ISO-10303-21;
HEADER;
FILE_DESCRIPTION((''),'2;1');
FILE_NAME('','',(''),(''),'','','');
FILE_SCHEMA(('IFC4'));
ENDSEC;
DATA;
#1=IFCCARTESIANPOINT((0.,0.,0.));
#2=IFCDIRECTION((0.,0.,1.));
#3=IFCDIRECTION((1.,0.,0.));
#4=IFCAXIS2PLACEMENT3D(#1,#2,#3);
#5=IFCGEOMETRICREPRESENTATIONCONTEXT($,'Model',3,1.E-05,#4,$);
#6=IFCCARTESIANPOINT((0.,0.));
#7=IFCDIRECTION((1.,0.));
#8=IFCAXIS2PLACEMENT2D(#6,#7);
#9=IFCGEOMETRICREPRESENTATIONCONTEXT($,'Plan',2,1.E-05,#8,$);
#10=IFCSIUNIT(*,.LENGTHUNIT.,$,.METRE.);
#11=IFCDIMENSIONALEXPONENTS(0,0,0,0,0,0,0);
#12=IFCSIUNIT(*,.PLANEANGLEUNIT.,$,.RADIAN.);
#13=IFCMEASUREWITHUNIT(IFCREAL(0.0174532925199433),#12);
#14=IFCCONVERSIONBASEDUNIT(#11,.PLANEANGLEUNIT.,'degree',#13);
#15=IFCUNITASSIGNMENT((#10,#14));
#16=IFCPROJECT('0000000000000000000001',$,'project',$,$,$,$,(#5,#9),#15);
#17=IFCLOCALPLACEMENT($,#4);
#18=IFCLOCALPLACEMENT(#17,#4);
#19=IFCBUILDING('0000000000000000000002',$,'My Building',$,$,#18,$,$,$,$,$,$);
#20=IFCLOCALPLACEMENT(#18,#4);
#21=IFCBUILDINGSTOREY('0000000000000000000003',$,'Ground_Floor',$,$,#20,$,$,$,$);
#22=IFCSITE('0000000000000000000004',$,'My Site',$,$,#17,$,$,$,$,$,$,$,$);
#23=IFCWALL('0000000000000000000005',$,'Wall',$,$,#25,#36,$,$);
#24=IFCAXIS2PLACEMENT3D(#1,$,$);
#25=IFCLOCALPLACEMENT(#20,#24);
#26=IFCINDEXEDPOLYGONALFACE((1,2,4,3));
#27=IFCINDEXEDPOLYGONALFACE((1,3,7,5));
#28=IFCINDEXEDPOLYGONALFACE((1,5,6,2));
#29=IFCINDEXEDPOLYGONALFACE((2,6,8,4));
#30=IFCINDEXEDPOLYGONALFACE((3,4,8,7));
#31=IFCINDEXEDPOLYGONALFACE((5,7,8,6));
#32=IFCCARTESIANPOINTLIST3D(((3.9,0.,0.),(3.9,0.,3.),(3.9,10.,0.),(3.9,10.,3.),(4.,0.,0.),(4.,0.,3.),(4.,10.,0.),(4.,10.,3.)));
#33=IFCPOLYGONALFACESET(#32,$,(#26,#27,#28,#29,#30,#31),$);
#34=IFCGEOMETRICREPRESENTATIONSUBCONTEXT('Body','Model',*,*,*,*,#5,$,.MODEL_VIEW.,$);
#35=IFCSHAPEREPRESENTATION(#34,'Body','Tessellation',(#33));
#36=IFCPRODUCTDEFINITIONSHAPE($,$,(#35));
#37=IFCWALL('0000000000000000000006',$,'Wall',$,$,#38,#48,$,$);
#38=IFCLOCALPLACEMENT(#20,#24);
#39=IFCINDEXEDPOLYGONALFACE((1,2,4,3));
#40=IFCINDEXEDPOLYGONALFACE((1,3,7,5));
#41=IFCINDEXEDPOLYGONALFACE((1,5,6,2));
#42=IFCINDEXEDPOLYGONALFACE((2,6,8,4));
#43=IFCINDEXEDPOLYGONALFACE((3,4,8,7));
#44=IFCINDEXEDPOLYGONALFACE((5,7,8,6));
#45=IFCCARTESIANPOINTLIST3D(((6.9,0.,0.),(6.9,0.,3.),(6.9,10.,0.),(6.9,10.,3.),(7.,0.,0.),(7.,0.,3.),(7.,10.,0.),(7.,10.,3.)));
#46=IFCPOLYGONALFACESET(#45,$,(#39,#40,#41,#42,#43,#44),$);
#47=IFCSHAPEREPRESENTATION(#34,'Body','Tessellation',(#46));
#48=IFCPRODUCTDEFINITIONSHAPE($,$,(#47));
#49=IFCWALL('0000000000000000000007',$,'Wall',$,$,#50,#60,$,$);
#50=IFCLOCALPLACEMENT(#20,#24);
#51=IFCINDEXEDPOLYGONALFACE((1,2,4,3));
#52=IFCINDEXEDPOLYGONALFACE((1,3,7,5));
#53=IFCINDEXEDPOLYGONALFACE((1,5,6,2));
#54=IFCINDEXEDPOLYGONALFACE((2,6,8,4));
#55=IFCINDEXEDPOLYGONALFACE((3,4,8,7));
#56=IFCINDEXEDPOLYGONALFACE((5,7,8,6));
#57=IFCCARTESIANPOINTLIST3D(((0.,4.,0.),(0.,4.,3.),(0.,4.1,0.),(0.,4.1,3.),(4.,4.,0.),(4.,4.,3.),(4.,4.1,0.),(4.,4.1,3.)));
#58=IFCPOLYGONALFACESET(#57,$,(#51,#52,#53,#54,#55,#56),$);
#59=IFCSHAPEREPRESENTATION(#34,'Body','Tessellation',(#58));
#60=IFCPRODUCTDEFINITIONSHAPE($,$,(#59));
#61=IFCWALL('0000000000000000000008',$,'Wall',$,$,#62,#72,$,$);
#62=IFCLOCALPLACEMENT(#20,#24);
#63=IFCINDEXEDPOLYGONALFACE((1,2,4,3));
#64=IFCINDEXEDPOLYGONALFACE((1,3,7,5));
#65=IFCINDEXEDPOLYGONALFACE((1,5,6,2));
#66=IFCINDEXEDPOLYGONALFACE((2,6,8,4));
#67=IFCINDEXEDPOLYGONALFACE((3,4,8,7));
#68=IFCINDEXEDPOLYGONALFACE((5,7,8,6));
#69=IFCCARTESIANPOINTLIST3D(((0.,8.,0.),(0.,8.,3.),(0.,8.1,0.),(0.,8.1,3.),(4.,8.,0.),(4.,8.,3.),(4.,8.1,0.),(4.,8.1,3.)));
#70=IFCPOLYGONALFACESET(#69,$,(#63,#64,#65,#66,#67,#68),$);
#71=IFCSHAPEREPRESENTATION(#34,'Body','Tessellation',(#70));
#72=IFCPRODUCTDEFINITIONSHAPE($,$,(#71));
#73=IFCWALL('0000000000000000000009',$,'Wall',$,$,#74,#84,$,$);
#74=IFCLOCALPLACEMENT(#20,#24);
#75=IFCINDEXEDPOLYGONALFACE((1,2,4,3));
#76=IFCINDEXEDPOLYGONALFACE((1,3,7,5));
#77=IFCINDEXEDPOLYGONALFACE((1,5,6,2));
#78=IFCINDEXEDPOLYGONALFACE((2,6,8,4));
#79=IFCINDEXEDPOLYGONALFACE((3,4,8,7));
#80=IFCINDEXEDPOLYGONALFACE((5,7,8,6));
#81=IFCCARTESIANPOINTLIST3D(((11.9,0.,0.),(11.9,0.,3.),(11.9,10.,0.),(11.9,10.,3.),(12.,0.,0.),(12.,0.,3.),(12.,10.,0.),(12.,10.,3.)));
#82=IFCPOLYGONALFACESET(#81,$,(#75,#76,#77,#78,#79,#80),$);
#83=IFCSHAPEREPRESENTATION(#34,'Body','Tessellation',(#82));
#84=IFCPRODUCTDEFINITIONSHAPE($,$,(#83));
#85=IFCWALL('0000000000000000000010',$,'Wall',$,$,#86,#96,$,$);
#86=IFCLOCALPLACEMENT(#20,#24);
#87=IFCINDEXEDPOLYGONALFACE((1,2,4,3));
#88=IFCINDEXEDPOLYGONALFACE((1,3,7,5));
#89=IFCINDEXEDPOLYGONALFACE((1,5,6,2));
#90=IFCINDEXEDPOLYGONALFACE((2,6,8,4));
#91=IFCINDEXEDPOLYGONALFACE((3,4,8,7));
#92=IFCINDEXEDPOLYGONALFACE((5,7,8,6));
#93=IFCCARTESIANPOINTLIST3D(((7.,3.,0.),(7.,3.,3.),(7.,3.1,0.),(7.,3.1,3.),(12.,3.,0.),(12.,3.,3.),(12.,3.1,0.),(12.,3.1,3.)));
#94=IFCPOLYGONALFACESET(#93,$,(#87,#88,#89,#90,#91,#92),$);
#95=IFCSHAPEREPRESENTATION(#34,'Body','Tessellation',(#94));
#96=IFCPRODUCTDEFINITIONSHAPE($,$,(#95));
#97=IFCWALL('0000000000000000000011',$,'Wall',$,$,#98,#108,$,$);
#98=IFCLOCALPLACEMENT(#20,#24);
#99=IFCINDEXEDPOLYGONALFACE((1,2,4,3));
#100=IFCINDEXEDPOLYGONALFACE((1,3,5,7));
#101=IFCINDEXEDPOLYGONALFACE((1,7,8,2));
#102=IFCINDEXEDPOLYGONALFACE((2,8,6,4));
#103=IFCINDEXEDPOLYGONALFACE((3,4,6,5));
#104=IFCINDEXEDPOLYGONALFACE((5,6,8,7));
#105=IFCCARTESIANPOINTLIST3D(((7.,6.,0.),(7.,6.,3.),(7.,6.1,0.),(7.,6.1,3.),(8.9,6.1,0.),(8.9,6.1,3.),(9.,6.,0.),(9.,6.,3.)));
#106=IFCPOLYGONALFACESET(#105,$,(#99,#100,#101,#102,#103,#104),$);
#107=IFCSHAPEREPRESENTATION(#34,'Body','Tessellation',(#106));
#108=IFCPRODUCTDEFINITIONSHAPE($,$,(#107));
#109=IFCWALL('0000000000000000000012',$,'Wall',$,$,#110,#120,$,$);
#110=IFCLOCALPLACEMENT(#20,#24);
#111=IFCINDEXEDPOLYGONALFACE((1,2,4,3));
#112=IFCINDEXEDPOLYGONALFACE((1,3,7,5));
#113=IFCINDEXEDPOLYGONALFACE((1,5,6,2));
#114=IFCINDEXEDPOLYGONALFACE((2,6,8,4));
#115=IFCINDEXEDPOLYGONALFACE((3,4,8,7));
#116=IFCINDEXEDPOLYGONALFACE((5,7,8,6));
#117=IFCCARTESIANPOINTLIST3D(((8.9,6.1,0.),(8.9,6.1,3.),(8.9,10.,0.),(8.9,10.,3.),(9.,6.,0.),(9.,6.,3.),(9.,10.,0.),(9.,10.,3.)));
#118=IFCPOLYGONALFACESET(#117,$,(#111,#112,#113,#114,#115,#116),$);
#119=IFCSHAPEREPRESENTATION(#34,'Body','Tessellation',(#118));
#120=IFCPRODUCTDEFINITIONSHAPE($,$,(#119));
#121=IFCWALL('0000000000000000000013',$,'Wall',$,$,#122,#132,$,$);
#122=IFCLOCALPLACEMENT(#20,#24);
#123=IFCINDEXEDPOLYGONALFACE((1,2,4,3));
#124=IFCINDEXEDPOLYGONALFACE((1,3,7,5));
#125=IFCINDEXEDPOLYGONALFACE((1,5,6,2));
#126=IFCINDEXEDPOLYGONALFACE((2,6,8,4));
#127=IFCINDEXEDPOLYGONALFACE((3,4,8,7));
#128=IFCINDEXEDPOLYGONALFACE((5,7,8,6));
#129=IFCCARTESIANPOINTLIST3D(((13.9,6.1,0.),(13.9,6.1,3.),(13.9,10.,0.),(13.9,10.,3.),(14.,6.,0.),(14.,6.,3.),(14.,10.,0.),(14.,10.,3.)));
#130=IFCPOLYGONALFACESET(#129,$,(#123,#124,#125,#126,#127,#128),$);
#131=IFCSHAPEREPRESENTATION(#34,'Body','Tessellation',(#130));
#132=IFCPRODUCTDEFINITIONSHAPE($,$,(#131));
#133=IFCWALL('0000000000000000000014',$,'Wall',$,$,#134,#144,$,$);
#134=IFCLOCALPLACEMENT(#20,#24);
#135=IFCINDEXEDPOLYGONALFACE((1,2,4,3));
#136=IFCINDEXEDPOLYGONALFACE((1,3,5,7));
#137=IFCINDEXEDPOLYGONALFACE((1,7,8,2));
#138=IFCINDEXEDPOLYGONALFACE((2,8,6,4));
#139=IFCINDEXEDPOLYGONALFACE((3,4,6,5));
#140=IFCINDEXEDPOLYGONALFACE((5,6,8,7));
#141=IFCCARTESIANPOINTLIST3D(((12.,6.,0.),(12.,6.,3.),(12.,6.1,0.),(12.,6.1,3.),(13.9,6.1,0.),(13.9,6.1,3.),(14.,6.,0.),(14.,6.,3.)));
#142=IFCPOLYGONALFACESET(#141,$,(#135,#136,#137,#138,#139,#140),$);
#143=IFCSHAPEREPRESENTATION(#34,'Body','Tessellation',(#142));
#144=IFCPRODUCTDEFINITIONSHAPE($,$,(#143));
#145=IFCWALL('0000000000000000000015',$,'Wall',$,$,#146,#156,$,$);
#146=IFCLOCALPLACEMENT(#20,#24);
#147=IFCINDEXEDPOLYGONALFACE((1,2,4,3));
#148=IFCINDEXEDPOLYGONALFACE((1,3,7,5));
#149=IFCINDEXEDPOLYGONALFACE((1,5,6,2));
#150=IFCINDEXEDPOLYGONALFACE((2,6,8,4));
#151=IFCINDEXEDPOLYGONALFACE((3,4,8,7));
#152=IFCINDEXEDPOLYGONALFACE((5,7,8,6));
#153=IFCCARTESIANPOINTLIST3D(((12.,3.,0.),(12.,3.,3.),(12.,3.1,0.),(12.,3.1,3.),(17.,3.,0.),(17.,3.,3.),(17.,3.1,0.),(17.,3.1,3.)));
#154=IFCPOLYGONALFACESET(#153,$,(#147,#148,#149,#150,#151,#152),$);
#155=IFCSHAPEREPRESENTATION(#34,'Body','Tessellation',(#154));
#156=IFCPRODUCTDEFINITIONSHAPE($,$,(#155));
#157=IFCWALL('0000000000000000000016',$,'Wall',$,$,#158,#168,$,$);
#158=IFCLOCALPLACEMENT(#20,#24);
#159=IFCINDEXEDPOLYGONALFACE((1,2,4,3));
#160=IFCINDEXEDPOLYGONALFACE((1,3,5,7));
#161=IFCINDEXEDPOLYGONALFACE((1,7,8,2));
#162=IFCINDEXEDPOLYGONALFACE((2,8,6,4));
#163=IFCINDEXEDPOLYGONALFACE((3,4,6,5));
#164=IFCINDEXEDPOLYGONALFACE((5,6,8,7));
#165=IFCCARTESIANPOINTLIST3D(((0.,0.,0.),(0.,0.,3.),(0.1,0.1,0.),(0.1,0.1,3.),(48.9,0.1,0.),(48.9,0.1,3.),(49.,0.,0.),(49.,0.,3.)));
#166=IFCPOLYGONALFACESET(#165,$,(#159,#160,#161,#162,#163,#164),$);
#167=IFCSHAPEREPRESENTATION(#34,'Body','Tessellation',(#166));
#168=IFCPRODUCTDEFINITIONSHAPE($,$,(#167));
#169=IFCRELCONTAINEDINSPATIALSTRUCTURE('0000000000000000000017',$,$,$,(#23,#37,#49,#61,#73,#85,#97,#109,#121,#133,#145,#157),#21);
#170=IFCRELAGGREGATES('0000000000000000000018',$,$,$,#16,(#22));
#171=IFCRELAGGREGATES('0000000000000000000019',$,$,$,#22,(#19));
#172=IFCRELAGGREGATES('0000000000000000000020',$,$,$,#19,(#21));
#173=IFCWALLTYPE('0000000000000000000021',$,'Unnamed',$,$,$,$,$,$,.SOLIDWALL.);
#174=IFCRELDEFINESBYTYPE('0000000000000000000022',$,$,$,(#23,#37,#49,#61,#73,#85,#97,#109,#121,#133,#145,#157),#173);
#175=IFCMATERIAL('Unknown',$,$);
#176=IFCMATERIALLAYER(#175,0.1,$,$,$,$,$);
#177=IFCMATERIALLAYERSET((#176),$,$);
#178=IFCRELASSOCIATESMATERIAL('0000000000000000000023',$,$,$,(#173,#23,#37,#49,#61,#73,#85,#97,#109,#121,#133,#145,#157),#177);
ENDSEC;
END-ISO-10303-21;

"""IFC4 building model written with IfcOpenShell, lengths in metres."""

from ifc_helpers import new_model, entity, si_unit, converted_unit, frame, origin_with_axes, origin_2d_with_axis, place, context, subcontext, project, spatial, line, indexed_curve, outline, extrude, material, layer, layer_set, layer_usage, type_object, element, save


model = new_model("IFC4")

# Units and contexts
model_context = context("Model", 3, precision=1e-05, world=origin_with_axes())
plan_context = context("Plan", 2, precision=1e-05, world=origin_2d_with_axis())
body_context = subcontext(model_context, "Body", "Model", "MODEL_VIEW")
ifc_project = project(units=[si_unit("LENGTHUNIT", "METRE"), converted_unit("PLANEANGLEUNIT", "degree", entity("IfcReal", 0.0174532925199433), si_unit("PLANEANGLEUNIT", "RADIAN"), dimensions=[0, 0, 0, 0, 0, 0, 0])], contexts=[model_context, plan_context])

# Site, building, storey
site_placement = place(None, origin_with_axes())
site = spatial("IfcSite", under=ifc_project, at=site_placement, Name="My Site")
building_placement = place(site_placement, origin_with_axes())
building = spatial("IfcBuilding", under=site, at=building_placement, Name="My Building")
storey_placement = place(building_placement, origin_with_axes())
storey = spatial("IfcBuildingStorey", under=building, at=storey_placement, Name="Ground_Floor")

# Walls
ifc_material = material(Name="Unknown")
ifc_layer = layer(ifc_material, 0.1)
ifc_layer_set = layer_set([ifc_layer])
ifc_layer_usage_1 = layer_usage(ifc_layer_set, "AXIS2", "POSITIVE", 0.0)
wall_type = type_object("IfcWallType", Name="Unnamed", PredefinedType="SOLIDWALL", material=ifc_layer_set)
wall_1_placement = place(storey_placement, frame((4.0, 0.0, 0.0), z_axis=(0.0, 0.0, 1.0), x_axis=(0.0, 1.0, 0.0)))
element("IfcWall", 1, at=wall_1_placement, inside=storey, type_object=wall_type, material=ifc_layer_usage_1, Name="Wall", context=body_context, shape_type="SweptSolid", body=[
    extrude(outline(indexed_curve([(0.0, 0.0), (0.0, 0.1), (10.0, 0.1), (10.0, 0.0)], segments=[line(1, 2, 3, 4, 1)])), origin_with_axes(), (0.0, 0.0, 1.0), 3.0),
])
ifc_layer_usage_2 = layer_usage(ifc_layer_set, "AXIS2", "POSITIVE", 0.0)
wall_2_placement = place(storey_placement, frame((7.0, 0.0, 0.0), z_axis=(0.0, 0.0, 1.0), x_axis=(0.0, 1.0, 0.0)))
element("IfcWall", 2, at=wall_2_placement, inside=storey, type_object=wall_type, material=ifc_layer_usage_2, Name="Wall", context=body_context, shape_type="SweptSolid", body=[
    extrude(outline(indexed_curve([(0.0, 0.0), (0.0, 0.1), (10.0, 0.1), (10.0, 0.0)], segments=[line(1, 2, 3, 4, 1)])), origin_with_axes(), (0.0, 0.0, 1.0), 3.0),
])
ifc_layer_usage_3 = layer_usage(ifc_layer_set, "AXIS2", "POSITIVE", 0.0)
wall_3_placement = place(storey_placement, frame((0.0, 4.0, 0.0), z_axis=(0.0, 0.0, 1.0), x_axis=(1.0, 0.0, 0.0)))
element("IfcWall", 3, at=wall_3_placement, inside=storey, type_object=wall_type, material=ifc_layer_usage_3, Name="Wall", context=body_context, shape_type="SweptSolid", body=[
    extrude(outline(indexed_curve([(0.0, 0.0), (0.0, 0.1), (4.0, 0.1), (4.0, 0.0)], segments=[line(1, 2, 3, 4, 1)])), origin_with_axes(), (0.0, 0.0, 1.0), 3.0),
])
ifc_layer_usage_4 = layer_usage(ifc_layer_set, "AXIS2", "POSITIVE", 0.0)
wall_4_placement = place(storey_placement, frame((0.0, 8.0, 0.0), z_axis=(0.0, 0.0, 1.0), x_axis=(1.0, 0.0, 0.0)))
element("IfcWall", 4, at=wall_4_placement, inside=storey, type_object=wall_type, material=ifc_layer_usage_4, Name="Wall", context=body_context, shape_type="SweptSolid", body=[
    extrude(outline(indexed_curve([(0.0, 0.0), (0.0, 0.1), (4.0, 0.1), (4.0, 0.0)], segments=[line(1, 2, 3, 4, 1)])), origin_with_axes(), (0.0, 0.0, 1.0), 3.0),
])
ifc_layer_usage_5 = layer_usage(ifc_layer_set, "AXIS2", "POSITIVE", 0.0)
wall_5_placement = place(storey_placement, frame((12.0, 0.0, 0.0), z_axis=(0.0, 0.0, 1.0), x_axis=(0.0, 1.0, 0.0)))
element("IfcWall", 5, at=wall_5_placement, inside=storey, type_object=wall_type, material=ifc_layer_usage_5, Name="Wall", context=body_context, shape_type="SweptSolid", body=[
    extrude(outline(indexed_curve([(0.0, 0.0), (0.0, 0.1), (10.0, 0.1), (10.0, 0.0)], segments=[line(1, 2, 3, 4, 1)])), origin_with_axes(), (0.0, 0.0, 1.0), 3.0),
])
ifc_layer_usage_6 = layer_usage(ifc_layer_set, "AXIS2", "POSITIVE", 0.0)
wall_6_placement = place(storey_placement, frame((7.0, 3.0, 0.0), z_axis=(0.0, 0.0, 1.0), x_axis=(1.0, 0.0, 0.0)))
element("IfcWall", 6, at=wall_6_placement, inside=storey, type_object=wall_type, material=ifc_layer_usage_6, Name="Wall", context=body_context, shape_type="SweptSolid", body=[
    extrude(outline(indexed_curve([(0.0, 0.0), (0.0, 0.1), (5.0, 0.1), (5.0, 0.0)], segments=[line(1, 2, 3, 4, 1)])), origin_with_axes(), (0.0, 0.0, 1.0), 3.0),
])
ifc_layer_usage_7 = layer_usage(ifc_layer_set, "AXIS2", "POSITIVE", 0.0)
wall_7_placement = place(storey_placement, frame((7.0, 6.0, 0.0), z_axis=(0.0, 0.0, 1.0), x_axis=(1.0, 0.0, 0.0)))
element("IfcWall", 7, at=wall_7_placement, inside=storey, type_object=wall_type, material=ifc_layer_usage_7, Name="Wall", context=body_context, shape_type="SweptSolid", body=[
    extrude(outline(indexed_curve([(0.0, 0.0), (0.0, 0.1), (1.9, 0.1), (2.0, 0.0)], segments=[line(1, 2, 3, 4, 1)])), origin_with_axes(), (0.0, 0.0, 1.0), 3.0),
])
ifc_layer_usage_8 = layer_usage(ifc_layer_set, "AXIS2", "POSITIVE", 0.0)
wall_8_placement = place(storey_placement, frame((9.0, 6.0, 0.0), z_axis=(0.0, 0.0, 1.0), x_axis=(0.0, 1.0, 0.0)))
element("IfcWall", 8, at=wall_8_placement, inside=storey, type_object=wall_type, material=ifc_layer_usage_8, Name="Wall", context=body_context, shape_type="SweptSolid", body=[
    extrude(outline(indexed_curve([(0.0, 0.0), (0.1, 0.1), (4.0, 0.1), (4.0, 0.0)], segments=[line(1, 2, 3, 4, 1)])), origin_with_axes(), (0.0, 0.0, 1.0), 3.0),
])
ifc_layer_usage_9 = layer_usage(ifc_layer_set, "AXIS2", "POSITIVE", 0.0)
wall_9_placement = place(storey_placement, frame((14.0, 6.0, 0.0), z_axis=(0.0, 0.0, 1.0), x_axis=(0.0, 1.0, 0.0)))
element("IfcWall", 9, at=wall_9_placement, inside=storey, type_object=wall_type, material=ifc_layer_usage_9, Name="Wall", context=body_context, shape_type="SweptSolid", body=[
    extrude(outline(indexed_curve([(0.0, 0.0), (0.1, 0.1), (4.0, 0.1), (4.0, 0.0)], segments=[line(1, 2, 3, 4, 1)])), origin_with_axes(), (0.0, 0.0, 1.0), 3.0),
])
ifc_layer_usage_10 = layer_usage(ifc_layer_set, "AXIS2", "POSITIVE", 0.0)
wall_10_placement = place(storey_placement, frame((12.0, 6.0, 0.0), z_axis=(0.0, 0.0, 1.0), x_axis=(1.0, 0.0, 0.0)))
element("IfcWall", 10, at=wall_10_placement, inside=storey, type_object=wall_type, material=ifc_layer_usage_10, Name="Wall", context=body_context, shape_type="SweptSolid", body=[
    extrude(outline(indexed_curve([(0.0, 0.0), (0.0, 0.1), (1.9, 0.1), (2.0, 0.0)], segments=[line(1, 2, 3, 4, 1)])), origin_with_axes(), (0.0, 0.0, 1.0), 3.0),
])
ifc_layer_usage_11 = layer_usage(ifc_layer_set, "AXIS2", "POSITIVE", 0.0)
wall_11_placement = place(storey_placement, frame((12.0, 3.0, 0.0), z_axis=(0.0, 0.0, 1.0), x_axis=(1.0, 0.0, 0.0)))
element("IfcWall", 11, at=wall_11_placement, inside=storey, type_object=wall_type, material=ifc_layer_usage_11, Name="Wall", context=body_context, shape_type="SweptSolid", body=[
    extrude(outline(indexed_curve([(0.0, 0.0), (0.0, 0.1), (5.0, 0.1), (5.0, 0.0)], segments=[line(1, 2, 3, 4, 1)])), origin_with_axes(), (0.0, 0.0, 1.0), 3.0),
])
ifc_layer_usage_12 = layer_usage(ifc_layer_set, "AXIS2", "POSITIVE", 0.0)
wall_12_placement = place(storey_placement, frame((0.0, 0.0, 0.0), z_axis=(0.0, 0.0, 1.0), x_axis=(1.0, 0.0, 0.0)))
element("IfcWall", 12, at=wall_12_placement, inside=storey, type_object=wall_type, material=ifc_layer_usage_12, Name="Wall", context=body_context, shape_type="SweptSolid", body=[
    extrude(outline(indexed_curve([(0.0, 0.0), (0.1, 0.1), (48.9, 0.1), (49.0, 0.0)], segments=[line(1, 2, 3, 4, 1)])), origin_with_axes(), (0.0, 0.0, 1.0), 3.0),
])

save(model, "model.ifc")
